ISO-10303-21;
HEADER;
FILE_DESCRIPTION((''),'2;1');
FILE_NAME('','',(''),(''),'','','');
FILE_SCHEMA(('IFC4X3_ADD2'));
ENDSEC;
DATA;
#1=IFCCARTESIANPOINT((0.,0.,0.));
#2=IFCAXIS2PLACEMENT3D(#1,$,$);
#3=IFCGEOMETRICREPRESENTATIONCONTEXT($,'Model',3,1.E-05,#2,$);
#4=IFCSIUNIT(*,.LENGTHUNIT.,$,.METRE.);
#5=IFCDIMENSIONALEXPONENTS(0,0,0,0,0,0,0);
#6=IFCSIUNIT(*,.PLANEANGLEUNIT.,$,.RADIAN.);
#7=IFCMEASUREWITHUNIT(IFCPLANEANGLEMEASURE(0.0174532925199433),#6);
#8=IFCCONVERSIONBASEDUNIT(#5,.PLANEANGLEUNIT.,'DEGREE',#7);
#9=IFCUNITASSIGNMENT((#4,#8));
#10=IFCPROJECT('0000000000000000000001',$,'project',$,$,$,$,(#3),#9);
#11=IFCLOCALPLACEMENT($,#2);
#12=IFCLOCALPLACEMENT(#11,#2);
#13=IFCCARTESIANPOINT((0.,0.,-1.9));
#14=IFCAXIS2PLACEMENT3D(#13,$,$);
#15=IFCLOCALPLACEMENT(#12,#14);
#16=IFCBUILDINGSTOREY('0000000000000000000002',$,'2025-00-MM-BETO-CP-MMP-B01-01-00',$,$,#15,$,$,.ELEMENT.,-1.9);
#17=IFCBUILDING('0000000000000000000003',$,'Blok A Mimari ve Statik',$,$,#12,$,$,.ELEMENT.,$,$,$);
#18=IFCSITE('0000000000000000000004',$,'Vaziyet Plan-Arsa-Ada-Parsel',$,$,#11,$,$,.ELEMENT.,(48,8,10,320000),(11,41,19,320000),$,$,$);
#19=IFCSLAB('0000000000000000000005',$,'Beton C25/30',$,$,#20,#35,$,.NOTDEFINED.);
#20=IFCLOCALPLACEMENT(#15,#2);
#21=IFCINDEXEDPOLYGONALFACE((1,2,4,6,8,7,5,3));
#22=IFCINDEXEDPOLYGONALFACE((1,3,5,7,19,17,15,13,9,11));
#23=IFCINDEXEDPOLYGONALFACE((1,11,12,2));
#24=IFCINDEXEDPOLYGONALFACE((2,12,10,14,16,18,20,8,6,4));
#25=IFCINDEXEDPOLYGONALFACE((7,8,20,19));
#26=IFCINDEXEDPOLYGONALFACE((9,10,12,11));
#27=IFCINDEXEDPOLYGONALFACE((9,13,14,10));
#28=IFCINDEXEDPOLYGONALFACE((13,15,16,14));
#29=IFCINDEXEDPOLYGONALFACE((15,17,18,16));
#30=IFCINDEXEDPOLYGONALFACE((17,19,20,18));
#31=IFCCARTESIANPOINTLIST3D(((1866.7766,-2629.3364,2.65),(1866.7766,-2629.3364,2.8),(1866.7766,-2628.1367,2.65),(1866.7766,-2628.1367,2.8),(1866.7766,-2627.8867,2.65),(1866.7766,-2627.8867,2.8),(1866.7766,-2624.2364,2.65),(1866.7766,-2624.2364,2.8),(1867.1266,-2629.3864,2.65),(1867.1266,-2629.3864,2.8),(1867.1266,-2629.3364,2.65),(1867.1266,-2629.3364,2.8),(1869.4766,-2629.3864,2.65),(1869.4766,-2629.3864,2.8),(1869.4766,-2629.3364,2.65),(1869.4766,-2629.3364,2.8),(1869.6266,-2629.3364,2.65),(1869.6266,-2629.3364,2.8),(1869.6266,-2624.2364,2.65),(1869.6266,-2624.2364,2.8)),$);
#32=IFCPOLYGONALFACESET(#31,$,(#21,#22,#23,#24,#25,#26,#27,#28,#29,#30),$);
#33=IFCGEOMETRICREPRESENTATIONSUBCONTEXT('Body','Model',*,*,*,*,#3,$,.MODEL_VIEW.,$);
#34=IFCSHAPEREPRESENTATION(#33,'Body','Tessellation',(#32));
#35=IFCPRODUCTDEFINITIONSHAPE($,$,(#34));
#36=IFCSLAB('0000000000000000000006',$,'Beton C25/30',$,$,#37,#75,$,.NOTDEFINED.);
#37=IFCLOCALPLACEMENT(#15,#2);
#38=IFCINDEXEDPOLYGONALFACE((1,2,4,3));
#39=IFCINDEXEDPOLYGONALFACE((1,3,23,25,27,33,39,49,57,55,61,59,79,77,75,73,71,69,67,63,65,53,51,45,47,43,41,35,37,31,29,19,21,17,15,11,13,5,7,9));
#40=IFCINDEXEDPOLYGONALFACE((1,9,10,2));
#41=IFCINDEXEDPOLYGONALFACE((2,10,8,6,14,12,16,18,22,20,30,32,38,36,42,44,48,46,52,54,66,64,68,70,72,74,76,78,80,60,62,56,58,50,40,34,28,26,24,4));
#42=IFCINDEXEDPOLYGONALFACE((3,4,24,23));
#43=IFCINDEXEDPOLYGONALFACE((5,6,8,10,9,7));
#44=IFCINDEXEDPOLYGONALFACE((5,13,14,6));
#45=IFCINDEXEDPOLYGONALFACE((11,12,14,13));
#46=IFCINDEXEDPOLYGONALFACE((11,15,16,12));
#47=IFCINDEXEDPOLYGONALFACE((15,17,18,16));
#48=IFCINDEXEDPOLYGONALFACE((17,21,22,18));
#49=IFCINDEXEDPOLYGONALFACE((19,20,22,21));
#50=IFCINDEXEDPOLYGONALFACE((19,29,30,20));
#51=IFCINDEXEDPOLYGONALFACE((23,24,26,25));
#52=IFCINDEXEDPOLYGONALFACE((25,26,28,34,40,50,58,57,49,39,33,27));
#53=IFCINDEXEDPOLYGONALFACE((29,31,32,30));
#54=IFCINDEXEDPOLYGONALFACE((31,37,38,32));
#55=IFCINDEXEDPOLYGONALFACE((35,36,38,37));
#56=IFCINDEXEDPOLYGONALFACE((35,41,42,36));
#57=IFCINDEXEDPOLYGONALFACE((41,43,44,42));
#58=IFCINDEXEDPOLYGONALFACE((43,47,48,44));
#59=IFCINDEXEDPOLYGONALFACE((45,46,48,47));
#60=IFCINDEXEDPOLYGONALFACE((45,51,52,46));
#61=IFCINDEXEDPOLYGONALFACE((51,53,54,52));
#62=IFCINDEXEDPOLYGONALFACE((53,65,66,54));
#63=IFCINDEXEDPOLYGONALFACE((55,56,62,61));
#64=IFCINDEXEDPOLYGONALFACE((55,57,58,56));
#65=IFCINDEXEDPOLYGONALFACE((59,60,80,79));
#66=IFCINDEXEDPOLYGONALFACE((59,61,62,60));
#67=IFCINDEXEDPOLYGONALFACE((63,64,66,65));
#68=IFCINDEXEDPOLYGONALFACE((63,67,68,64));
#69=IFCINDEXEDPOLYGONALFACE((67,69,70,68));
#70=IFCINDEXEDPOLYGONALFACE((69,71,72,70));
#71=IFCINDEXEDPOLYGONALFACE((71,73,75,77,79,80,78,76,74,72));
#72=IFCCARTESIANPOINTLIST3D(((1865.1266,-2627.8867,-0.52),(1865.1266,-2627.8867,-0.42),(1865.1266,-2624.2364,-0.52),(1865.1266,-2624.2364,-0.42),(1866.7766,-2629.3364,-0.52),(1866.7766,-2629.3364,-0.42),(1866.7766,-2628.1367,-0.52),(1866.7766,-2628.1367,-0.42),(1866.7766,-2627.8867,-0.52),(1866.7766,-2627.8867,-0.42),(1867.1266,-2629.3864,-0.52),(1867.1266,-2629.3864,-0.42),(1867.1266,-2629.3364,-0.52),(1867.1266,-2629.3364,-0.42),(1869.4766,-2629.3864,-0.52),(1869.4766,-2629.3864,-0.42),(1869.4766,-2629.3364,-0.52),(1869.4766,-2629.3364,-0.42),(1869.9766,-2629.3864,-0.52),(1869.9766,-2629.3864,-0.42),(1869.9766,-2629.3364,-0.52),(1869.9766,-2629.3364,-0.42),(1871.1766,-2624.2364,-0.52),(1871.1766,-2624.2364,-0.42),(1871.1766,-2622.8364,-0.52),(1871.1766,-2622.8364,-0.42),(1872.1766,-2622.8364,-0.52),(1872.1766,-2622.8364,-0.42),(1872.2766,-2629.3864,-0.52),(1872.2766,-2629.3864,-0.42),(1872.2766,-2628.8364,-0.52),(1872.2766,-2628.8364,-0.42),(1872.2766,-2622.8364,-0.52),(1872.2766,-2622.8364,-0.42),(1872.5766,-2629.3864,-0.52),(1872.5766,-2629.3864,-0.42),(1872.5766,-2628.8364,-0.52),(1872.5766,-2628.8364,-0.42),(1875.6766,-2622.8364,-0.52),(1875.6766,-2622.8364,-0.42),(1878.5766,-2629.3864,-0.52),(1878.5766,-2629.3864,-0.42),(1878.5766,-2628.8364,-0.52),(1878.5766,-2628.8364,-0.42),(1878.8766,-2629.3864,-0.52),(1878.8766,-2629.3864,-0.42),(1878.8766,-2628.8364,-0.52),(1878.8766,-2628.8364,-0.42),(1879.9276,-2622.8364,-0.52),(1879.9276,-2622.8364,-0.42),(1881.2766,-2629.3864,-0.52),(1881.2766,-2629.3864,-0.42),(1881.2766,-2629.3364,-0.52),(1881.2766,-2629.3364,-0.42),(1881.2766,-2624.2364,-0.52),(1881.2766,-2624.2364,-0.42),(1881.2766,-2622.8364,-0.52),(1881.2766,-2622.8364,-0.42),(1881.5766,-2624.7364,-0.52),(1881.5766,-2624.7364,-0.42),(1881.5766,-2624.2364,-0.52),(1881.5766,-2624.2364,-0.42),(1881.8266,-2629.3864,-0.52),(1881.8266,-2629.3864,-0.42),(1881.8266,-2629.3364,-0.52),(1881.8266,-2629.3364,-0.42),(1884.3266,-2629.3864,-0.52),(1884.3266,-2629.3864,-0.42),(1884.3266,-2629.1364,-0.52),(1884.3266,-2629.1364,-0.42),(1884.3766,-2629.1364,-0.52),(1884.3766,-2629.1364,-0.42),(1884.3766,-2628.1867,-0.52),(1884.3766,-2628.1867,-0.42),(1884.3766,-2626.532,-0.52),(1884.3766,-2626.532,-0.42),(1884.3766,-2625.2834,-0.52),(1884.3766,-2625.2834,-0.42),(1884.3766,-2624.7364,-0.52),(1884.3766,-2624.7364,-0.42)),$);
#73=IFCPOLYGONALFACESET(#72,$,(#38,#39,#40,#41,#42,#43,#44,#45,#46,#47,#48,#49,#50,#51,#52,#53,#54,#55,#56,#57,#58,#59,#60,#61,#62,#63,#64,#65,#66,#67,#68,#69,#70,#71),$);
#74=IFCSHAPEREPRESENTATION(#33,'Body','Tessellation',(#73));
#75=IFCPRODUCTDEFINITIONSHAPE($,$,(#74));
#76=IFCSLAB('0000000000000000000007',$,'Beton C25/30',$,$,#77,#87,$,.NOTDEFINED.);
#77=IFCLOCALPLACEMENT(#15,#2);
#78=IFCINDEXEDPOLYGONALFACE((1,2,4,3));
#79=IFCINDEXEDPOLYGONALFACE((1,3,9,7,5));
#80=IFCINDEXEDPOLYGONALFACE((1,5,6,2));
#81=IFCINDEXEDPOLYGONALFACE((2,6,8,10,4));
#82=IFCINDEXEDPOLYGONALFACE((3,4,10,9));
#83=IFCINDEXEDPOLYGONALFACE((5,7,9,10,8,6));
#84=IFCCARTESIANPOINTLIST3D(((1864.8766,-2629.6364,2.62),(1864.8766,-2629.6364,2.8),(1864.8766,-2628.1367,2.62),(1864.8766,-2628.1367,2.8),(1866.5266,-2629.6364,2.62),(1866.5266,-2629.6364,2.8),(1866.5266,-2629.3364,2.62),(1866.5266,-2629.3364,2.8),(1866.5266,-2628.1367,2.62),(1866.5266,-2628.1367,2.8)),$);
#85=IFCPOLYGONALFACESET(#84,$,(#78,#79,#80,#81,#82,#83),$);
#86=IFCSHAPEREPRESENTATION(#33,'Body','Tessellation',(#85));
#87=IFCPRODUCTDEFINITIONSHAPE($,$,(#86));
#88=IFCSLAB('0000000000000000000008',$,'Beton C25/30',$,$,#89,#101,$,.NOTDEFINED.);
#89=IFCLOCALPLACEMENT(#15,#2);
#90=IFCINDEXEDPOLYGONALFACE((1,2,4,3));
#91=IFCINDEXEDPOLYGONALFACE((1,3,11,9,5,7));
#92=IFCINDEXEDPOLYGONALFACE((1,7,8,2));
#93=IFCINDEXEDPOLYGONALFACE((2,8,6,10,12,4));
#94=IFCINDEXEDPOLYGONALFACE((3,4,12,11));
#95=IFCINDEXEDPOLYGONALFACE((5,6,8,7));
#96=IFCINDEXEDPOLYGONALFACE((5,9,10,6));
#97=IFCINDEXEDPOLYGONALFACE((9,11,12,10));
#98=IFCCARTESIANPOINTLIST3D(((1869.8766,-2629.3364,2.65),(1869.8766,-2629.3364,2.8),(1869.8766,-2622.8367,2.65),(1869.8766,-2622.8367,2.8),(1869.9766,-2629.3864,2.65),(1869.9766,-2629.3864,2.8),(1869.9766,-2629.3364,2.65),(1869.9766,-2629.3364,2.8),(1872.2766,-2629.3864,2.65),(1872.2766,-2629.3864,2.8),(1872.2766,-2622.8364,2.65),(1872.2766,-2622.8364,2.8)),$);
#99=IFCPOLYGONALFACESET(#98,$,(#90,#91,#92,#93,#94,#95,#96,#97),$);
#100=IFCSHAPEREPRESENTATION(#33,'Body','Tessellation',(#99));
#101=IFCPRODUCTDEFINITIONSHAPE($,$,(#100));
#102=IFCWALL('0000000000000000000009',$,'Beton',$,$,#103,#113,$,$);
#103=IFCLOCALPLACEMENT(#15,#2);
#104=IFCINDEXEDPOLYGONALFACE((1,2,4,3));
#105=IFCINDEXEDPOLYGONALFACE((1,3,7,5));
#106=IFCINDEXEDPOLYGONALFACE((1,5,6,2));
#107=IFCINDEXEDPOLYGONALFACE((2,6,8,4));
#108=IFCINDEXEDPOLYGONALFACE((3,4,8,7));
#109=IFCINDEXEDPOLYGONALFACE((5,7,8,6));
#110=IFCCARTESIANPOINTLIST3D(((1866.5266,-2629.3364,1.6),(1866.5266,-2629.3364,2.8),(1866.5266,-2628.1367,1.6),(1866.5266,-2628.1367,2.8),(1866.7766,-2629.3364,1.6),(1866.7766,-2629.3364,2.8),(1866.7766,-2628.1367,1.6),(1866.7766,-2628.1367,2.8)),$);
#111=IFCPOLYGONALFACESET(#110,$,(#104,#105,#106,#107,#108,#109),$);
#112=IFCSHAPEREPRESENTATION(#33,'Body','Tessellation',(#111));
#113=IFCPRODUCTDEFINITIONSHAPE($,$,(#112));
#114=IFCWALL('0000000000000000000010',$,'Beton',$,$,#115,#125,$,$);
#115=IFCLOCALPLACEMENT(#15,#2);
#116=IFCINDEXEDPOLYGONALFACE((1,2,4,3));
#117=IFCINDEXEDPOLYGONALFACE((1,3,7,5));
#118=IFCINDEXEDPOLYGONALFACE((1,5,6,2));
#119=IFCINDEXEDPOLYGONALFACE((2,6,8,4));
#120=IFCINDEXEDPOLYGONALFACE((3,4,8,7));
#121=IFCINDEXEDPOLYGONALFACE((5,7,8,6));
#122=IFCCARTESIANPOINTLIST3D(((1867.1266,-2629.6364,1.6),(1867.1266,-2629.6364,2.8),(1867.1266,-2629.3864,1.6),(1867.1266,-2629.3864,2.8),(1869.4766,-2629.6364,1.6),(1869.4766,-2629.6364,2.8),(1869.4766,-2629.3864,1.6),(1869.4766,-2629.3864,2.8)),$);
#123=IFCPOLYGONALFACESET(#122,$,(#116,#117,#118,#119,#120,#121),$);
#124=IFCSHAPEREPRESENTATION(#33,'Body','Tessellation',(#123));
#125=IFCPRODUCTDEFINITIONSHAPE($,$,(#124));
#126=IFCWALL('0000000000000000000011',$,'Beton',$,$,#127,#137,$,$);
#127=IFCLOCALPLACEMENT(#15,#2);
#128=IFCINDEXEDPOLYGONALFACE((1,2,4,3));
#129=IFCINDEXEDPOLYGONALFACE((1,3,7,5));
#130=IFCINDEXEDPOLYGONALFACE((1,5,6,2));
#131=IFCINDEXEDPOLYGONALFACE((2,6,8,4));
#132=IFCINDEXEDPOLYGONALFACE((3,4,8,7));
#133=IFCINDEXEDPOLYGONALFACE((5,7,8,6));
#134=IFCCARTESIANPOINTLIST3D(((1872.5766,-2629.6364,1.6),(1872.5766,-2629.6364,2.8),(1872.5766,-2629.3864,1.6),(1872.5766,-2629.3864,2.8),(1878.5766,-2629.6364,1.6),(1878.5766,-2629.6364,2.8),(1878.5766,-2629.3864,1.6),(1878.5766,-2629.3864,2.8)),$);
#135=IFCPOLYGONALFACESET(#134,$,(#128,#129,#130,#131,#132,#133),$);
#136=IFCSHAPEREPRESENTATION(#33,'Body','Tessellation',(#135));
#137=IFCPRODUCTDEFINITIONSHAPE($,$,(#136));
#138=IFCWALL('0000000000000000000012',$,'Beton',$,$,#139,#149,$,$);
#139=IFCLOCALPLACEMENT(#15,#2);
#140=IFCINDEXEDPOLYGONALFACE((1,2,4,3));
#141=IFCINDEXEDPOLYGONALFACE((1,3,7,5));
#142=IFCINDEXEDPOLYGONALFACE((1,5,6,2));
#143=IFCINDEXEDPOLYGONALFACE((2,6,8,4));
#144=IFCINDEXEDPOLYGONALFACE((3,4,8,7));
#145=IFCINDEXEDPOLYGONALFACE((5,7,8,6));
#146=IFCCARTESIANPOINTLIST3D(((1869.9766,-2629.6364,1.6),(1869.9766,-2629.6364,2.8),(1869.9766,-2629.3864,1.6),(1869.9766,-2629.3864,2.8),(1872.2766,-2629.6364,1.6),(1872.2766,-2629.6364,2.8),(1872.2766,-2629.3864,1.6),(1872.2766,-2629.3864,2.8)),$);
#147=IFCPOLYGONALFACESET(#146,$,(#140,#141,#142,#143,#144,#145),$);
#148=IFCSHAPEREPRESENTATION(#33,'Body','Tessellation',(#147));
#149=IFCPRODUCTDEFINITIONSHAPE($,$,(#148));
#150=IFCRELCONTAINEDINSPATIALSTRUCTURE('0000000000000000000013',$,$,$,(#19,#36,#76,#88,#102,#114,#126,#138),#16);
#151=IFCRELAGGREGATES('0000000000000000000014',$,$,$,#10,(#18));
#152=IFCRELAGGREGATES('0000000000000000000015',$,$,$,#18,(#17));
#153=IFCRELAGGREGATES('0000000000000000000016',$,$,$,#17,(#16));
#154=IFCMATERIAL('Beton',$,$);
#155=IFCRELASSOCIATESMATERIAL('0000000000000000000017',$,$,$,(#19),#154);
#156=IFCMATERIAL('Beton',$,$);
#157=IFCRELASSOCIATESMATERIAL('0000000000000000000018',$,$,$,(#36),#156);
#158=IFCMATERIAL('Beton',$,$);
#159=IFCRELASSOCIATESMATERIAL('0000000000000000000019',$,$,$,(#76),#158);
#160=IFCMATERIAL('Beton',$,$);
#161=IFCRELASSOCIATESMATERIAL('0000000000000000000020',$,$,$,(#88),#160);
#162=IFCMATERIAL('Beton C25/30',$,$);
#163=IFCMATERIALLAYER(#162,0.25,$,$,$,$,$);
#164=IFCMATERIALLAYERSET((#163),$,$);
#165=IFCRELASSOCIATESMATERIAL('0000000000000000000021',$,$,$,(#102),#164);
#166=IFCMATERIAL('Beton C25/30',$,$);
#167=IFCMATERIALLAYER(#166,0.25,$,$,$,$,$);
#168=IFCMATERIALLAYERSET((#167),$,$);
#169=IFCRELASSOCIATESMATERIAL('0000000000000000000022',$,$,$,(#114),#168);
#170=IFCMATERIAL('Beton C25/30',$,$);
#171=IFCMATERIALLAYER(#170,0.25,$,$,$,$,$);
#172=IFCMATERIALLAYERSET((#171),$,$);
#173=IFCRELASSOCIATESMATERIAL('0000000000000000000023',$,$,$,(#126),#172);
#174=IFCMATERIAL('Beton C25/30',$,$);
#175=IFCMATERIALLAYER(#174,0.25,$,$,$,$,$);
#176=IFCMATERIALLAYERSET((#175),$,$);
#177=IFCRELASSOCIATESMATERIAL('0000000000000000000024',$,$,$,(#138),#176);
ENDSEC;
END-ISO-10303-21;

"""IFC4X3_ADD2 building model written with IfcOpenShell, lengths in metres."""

from ifc_helpers import new_model, entity, si_unit, converted_unit, frame, frame_2d, origin, origin_with_axes, place, context, subcontext, project, spatial, polyline, rectangle, outline, extrude, material, layer, layer_set, layer_usage, element, save


model = new_model("IFC4X3_ADD2")

# Units and contexts
model_context = context("Model", 3, precision=1e-05, world=origin())
body_context = subcontext(model_context, "Body", "Model", "MODEL_VIEW")
ifc_project = project(units=[si_unit("LENGTHUNIT", "METRE"), converted_unit("PLANEANGLEUNIT", "DEGREE", entity("IfcPlaneAngleMeasure", 0.0174532925199433), si_unit("PLANEANGLEUNIT", "RADIAN"), dimensions=[0, 0, 0, 0, 0, 0, 0])], contexts=[model_context])

# Site, building, storey
site_placement = place(None, origin())
site = spatial("IfcSite", under=ifc_project, at=site_placement, Name="Vaziyet Plan-Arsa-Ada-Parsel", CompositionType="ELEMENT", RefLatitude=(48, 8, 10, 320000), RefLongitude=(11, 41, 19, 320000))
building_placement = place(site_placement, origin())
building = spatial("IfcBuilding", under=site, at=building_placement, Name="Blok A Mimari ve Statik", CompositionType="ELEMENT")
storey_placement = place(building_placement, frame((0.0, 0.0, -1.9)))
storey = spatial("IfcBuildingStorey", under=building, at=storey_placement, Name="2025-00-MM-BETO-CP-MMP-B01-01-00", CompositionType="ELEMENT", Elevation=-1.9)

# Slabs
ifc_material_1 = material(Name="Beton")
slab_1_placement = place(storey_placement, frame((1866.7766, -2629.3864, 2.65)))
element("IfcSlab", 1, at=slab_1_placement, inside=storey, material=ifc_material_1, Name="Beton C25/30", PredefinedType="NOTDEFINED", context=body_context, shape_type="SweptSolid", body=[
    extrude(outline(polyline([(0.0, 1.4997), (0.0, 1.2497), (0.0, 0.05), (0.35, 0.05), (0.35, 0.0), (2.7, 0.0), (2.7, 0.05), (2.85, 0.05), (2.85, 5.15), (0.0, 5.15), (0.0, 1.4997)])), origin_with_axes(), (0.0, 0.0, 1.0), 0.15),
])
ifc_material_2 = material(Name="Beton")
slab_2_placement = place(storey_placement, frame((1865.1266, -2629.3864, -0.52)))
element("IfcSlab", 2, at=slab_2_placement, inside=storey, material=ifc_material_2, Name="Beton C25/30", PredefinedType="NOTDEFINED", context=body_context, shape_type="SweptSolid", body=[
    extrude(outline(polyline([(16.45, 4.65), (16.45, 5.15), (16.15, 5.15), (16.15, 6.55), (14.801, 6.55), (10.55, 6.55), (7.15, 6.55), (7.05, 6.55), (6.05, 6.55), (6.05, 5.15), (0.0, 5.15), (0.0, 1.4997), (1.65, 1.4997), (1.65, 1.2497), (1.65, 0.05), (2.0, 0.05), (2.0, 0.0), (4.35, 0.0), (4.35, 0.05), (4.85, 0.05), (4.85, 0.0), (7.15, 0.0), (7.15, 0.55), (7.45, 0.55), (7.45, 0.0), (13.45, 0.0), (13.45, 0.55), (13.75, 0.55), (13.75, 0.0), (16.15, 0.0), (16.15, 0.05), (16.7, 0.05), (16.7, 0.0), (19.2, 0.0), (19.2, 0.25), (19.25, 0.25), (19.25, 1.1997), (19.25, 2.8545), (19.25, 4.103), (19.25, 4.65), (16.45, 4.65)])), origin_with_axes(), (0.0, 0.0, 1.0), 0.1),
])
ifc_material_3 = material(Name="Beton")
slab_3_placement = place(storey_placement, frame((1864.8766, -2629.6364, 2.62)))
element("IfcSlab", 3, at=slab_3_placement, inside=storey, material=ifc_material_3, Name="Beton C25/30", PredefinedType="NOTDEFINED", context=body_context, shape_type="SweptSolid", body=[
    extrude(outline(polyline([(0.0, 0.0), (1.65, 0.0), (1.65, 0.3), (1.65, 1.4997), (0.0, 1.4997), (0.0, 0.0)])), origin_with_axes(), (0.0, 0.0, 1.0), 0.18),
])
ifc_material_4 = material(Name="Beton")
slab_4_placement = place(storey_placement, frame((1869.8766, -2629.3864, 2.65)))
element("IfcSlab", 4, at=slab_4_placement, inside=storey, material=ifc_material_4, Name="Beton C25/30", PredefinedType="NOTDEFINED", context=body_context, shape_type="SweptSolid", body=[
    extrude(outline(polyline([(0.0, 6.5497), (0.0, 0.05), (0.1, 0.05), (0.1, 0.0), (2.4, 0.0), (2.4, 6.55), (0.0, 6.5497)])), origin_with_axes(), (0.0, 0.0, 1.0), 0.15),
])

# Walls
ifc_material_5 = material(Name="Beton C25/30")
ifc_layer_1 = layer(ifc_material_5, 0.25)
ifc_layer_set_1 = layer_set([ifc_layer_1])
ifc_layer_usage_1 = layer_usage(ifc_layer_set_1, "AXIS2", "POSITIVE", 0.0)
wall_1_placement = place(storey_placement, frame((1866.5266, -2628.1367, 1.6), z_axis=(0.0, 0.0, 1.0), x_axis=(0.0, -1.0, 0.0)))
element("IfcWall", 5, at=wall_1_placement, inside=storey, material=ifc_layer_usage_1, Name="Beton", context=body_context, shape_type="SweptSolid", body=[
    extrude(rectangle(XDim=1.1997, YDim=0.25, at=frame_2d((0.5998, 0.125), x_axis=(1.0, 0.0))), origin_with_axes(), (0.0, 0.0, 1.0), 1.2),
])
ifc_material_6 = material(Name="Beton C25/30")
ifc_layer_2 = layer(ifc_material_6, 0.25)
ifc_layer_set_2 = layer_set([ifc_layer_2])
ifc_layer_usage_2 = layer_usage(ifc_layer_set_2, "AXIS2", "POSITIVE", 0.0)
wall_2_placement = place(storey_placement, frame((1867.1266, -2629.6364, 1.6)))
element("IfcWall", 6, at=wall_2_placement, inside=storey, material=ifc_layer_usage_2, Name="Beton", context=body_context, shape_type="SweptSolid", body=[
    extrude(rectangle(XDim=2.35, YDim=0.25, at=frame_2d((1.175, 0.125), x_axis=(1.0, 0.0))), origin_with_axes(), (0.0, 0.0, 1.0), 1.2),
])
ifc_material_7 = material(Name="Beton C25/30")
ifc_layer_3 = layer(ifc_material_7, 0.25)
ifc_layer_set_3 = layer_set([ifc_layer_3])
ifc_layer_usage_3 = layer_usage(ifc_layer_set_3, "AXIS2", "POSITIVE", 0.0)
wall_3_placement = place(storey_placement, frame((1872.5766, -2629.6364, 1.6)))
element("IfcWall", 7, at=wall_3_placement, inside=storey, material=ifc_layer_usage_3, Name="Beton", context=body_context, shape_type="SweptSolid", body=[
    extrude(rectangle(XDim=6.0, YDim=0.25, at=frame_2d((3.0, 0.125), x_axis=(1.0, 0.0))), origin_with_axes(), (0.0, 0.0, 1.0), 1.2),
])
ifc_material_8 = material(Name="Beton C25/30")
ifc_layer_4 = layer(ifc_material_8, 0.25)
ifc_layer_set_4 = layer_set([ifc_layer_4])
ifc_layer_usage_4 = layer_usage(ifc_layer_set_4, "AXIS2", "POSITIVE", 0.0)
wall_4_placement = place(storey_placement, frame((1869.9766, -2629.6364, 1.6)))
element("IfcWall", 8, at=wall_4_placement, inside=storey, material=ifc_layer_usage_4, Name="Beton", context=body_context, shape_type="SweptSolid", body=[
    extrude(rectangle(XDim=2.3, YDim=0.25, at=frame_2d((1.15, 0.125), x_axis=(1.0, 0.0))), origin_with_axes(), (0.0, 0.0, 1.0), 1.2),
])

save(model, "model.ifc")
